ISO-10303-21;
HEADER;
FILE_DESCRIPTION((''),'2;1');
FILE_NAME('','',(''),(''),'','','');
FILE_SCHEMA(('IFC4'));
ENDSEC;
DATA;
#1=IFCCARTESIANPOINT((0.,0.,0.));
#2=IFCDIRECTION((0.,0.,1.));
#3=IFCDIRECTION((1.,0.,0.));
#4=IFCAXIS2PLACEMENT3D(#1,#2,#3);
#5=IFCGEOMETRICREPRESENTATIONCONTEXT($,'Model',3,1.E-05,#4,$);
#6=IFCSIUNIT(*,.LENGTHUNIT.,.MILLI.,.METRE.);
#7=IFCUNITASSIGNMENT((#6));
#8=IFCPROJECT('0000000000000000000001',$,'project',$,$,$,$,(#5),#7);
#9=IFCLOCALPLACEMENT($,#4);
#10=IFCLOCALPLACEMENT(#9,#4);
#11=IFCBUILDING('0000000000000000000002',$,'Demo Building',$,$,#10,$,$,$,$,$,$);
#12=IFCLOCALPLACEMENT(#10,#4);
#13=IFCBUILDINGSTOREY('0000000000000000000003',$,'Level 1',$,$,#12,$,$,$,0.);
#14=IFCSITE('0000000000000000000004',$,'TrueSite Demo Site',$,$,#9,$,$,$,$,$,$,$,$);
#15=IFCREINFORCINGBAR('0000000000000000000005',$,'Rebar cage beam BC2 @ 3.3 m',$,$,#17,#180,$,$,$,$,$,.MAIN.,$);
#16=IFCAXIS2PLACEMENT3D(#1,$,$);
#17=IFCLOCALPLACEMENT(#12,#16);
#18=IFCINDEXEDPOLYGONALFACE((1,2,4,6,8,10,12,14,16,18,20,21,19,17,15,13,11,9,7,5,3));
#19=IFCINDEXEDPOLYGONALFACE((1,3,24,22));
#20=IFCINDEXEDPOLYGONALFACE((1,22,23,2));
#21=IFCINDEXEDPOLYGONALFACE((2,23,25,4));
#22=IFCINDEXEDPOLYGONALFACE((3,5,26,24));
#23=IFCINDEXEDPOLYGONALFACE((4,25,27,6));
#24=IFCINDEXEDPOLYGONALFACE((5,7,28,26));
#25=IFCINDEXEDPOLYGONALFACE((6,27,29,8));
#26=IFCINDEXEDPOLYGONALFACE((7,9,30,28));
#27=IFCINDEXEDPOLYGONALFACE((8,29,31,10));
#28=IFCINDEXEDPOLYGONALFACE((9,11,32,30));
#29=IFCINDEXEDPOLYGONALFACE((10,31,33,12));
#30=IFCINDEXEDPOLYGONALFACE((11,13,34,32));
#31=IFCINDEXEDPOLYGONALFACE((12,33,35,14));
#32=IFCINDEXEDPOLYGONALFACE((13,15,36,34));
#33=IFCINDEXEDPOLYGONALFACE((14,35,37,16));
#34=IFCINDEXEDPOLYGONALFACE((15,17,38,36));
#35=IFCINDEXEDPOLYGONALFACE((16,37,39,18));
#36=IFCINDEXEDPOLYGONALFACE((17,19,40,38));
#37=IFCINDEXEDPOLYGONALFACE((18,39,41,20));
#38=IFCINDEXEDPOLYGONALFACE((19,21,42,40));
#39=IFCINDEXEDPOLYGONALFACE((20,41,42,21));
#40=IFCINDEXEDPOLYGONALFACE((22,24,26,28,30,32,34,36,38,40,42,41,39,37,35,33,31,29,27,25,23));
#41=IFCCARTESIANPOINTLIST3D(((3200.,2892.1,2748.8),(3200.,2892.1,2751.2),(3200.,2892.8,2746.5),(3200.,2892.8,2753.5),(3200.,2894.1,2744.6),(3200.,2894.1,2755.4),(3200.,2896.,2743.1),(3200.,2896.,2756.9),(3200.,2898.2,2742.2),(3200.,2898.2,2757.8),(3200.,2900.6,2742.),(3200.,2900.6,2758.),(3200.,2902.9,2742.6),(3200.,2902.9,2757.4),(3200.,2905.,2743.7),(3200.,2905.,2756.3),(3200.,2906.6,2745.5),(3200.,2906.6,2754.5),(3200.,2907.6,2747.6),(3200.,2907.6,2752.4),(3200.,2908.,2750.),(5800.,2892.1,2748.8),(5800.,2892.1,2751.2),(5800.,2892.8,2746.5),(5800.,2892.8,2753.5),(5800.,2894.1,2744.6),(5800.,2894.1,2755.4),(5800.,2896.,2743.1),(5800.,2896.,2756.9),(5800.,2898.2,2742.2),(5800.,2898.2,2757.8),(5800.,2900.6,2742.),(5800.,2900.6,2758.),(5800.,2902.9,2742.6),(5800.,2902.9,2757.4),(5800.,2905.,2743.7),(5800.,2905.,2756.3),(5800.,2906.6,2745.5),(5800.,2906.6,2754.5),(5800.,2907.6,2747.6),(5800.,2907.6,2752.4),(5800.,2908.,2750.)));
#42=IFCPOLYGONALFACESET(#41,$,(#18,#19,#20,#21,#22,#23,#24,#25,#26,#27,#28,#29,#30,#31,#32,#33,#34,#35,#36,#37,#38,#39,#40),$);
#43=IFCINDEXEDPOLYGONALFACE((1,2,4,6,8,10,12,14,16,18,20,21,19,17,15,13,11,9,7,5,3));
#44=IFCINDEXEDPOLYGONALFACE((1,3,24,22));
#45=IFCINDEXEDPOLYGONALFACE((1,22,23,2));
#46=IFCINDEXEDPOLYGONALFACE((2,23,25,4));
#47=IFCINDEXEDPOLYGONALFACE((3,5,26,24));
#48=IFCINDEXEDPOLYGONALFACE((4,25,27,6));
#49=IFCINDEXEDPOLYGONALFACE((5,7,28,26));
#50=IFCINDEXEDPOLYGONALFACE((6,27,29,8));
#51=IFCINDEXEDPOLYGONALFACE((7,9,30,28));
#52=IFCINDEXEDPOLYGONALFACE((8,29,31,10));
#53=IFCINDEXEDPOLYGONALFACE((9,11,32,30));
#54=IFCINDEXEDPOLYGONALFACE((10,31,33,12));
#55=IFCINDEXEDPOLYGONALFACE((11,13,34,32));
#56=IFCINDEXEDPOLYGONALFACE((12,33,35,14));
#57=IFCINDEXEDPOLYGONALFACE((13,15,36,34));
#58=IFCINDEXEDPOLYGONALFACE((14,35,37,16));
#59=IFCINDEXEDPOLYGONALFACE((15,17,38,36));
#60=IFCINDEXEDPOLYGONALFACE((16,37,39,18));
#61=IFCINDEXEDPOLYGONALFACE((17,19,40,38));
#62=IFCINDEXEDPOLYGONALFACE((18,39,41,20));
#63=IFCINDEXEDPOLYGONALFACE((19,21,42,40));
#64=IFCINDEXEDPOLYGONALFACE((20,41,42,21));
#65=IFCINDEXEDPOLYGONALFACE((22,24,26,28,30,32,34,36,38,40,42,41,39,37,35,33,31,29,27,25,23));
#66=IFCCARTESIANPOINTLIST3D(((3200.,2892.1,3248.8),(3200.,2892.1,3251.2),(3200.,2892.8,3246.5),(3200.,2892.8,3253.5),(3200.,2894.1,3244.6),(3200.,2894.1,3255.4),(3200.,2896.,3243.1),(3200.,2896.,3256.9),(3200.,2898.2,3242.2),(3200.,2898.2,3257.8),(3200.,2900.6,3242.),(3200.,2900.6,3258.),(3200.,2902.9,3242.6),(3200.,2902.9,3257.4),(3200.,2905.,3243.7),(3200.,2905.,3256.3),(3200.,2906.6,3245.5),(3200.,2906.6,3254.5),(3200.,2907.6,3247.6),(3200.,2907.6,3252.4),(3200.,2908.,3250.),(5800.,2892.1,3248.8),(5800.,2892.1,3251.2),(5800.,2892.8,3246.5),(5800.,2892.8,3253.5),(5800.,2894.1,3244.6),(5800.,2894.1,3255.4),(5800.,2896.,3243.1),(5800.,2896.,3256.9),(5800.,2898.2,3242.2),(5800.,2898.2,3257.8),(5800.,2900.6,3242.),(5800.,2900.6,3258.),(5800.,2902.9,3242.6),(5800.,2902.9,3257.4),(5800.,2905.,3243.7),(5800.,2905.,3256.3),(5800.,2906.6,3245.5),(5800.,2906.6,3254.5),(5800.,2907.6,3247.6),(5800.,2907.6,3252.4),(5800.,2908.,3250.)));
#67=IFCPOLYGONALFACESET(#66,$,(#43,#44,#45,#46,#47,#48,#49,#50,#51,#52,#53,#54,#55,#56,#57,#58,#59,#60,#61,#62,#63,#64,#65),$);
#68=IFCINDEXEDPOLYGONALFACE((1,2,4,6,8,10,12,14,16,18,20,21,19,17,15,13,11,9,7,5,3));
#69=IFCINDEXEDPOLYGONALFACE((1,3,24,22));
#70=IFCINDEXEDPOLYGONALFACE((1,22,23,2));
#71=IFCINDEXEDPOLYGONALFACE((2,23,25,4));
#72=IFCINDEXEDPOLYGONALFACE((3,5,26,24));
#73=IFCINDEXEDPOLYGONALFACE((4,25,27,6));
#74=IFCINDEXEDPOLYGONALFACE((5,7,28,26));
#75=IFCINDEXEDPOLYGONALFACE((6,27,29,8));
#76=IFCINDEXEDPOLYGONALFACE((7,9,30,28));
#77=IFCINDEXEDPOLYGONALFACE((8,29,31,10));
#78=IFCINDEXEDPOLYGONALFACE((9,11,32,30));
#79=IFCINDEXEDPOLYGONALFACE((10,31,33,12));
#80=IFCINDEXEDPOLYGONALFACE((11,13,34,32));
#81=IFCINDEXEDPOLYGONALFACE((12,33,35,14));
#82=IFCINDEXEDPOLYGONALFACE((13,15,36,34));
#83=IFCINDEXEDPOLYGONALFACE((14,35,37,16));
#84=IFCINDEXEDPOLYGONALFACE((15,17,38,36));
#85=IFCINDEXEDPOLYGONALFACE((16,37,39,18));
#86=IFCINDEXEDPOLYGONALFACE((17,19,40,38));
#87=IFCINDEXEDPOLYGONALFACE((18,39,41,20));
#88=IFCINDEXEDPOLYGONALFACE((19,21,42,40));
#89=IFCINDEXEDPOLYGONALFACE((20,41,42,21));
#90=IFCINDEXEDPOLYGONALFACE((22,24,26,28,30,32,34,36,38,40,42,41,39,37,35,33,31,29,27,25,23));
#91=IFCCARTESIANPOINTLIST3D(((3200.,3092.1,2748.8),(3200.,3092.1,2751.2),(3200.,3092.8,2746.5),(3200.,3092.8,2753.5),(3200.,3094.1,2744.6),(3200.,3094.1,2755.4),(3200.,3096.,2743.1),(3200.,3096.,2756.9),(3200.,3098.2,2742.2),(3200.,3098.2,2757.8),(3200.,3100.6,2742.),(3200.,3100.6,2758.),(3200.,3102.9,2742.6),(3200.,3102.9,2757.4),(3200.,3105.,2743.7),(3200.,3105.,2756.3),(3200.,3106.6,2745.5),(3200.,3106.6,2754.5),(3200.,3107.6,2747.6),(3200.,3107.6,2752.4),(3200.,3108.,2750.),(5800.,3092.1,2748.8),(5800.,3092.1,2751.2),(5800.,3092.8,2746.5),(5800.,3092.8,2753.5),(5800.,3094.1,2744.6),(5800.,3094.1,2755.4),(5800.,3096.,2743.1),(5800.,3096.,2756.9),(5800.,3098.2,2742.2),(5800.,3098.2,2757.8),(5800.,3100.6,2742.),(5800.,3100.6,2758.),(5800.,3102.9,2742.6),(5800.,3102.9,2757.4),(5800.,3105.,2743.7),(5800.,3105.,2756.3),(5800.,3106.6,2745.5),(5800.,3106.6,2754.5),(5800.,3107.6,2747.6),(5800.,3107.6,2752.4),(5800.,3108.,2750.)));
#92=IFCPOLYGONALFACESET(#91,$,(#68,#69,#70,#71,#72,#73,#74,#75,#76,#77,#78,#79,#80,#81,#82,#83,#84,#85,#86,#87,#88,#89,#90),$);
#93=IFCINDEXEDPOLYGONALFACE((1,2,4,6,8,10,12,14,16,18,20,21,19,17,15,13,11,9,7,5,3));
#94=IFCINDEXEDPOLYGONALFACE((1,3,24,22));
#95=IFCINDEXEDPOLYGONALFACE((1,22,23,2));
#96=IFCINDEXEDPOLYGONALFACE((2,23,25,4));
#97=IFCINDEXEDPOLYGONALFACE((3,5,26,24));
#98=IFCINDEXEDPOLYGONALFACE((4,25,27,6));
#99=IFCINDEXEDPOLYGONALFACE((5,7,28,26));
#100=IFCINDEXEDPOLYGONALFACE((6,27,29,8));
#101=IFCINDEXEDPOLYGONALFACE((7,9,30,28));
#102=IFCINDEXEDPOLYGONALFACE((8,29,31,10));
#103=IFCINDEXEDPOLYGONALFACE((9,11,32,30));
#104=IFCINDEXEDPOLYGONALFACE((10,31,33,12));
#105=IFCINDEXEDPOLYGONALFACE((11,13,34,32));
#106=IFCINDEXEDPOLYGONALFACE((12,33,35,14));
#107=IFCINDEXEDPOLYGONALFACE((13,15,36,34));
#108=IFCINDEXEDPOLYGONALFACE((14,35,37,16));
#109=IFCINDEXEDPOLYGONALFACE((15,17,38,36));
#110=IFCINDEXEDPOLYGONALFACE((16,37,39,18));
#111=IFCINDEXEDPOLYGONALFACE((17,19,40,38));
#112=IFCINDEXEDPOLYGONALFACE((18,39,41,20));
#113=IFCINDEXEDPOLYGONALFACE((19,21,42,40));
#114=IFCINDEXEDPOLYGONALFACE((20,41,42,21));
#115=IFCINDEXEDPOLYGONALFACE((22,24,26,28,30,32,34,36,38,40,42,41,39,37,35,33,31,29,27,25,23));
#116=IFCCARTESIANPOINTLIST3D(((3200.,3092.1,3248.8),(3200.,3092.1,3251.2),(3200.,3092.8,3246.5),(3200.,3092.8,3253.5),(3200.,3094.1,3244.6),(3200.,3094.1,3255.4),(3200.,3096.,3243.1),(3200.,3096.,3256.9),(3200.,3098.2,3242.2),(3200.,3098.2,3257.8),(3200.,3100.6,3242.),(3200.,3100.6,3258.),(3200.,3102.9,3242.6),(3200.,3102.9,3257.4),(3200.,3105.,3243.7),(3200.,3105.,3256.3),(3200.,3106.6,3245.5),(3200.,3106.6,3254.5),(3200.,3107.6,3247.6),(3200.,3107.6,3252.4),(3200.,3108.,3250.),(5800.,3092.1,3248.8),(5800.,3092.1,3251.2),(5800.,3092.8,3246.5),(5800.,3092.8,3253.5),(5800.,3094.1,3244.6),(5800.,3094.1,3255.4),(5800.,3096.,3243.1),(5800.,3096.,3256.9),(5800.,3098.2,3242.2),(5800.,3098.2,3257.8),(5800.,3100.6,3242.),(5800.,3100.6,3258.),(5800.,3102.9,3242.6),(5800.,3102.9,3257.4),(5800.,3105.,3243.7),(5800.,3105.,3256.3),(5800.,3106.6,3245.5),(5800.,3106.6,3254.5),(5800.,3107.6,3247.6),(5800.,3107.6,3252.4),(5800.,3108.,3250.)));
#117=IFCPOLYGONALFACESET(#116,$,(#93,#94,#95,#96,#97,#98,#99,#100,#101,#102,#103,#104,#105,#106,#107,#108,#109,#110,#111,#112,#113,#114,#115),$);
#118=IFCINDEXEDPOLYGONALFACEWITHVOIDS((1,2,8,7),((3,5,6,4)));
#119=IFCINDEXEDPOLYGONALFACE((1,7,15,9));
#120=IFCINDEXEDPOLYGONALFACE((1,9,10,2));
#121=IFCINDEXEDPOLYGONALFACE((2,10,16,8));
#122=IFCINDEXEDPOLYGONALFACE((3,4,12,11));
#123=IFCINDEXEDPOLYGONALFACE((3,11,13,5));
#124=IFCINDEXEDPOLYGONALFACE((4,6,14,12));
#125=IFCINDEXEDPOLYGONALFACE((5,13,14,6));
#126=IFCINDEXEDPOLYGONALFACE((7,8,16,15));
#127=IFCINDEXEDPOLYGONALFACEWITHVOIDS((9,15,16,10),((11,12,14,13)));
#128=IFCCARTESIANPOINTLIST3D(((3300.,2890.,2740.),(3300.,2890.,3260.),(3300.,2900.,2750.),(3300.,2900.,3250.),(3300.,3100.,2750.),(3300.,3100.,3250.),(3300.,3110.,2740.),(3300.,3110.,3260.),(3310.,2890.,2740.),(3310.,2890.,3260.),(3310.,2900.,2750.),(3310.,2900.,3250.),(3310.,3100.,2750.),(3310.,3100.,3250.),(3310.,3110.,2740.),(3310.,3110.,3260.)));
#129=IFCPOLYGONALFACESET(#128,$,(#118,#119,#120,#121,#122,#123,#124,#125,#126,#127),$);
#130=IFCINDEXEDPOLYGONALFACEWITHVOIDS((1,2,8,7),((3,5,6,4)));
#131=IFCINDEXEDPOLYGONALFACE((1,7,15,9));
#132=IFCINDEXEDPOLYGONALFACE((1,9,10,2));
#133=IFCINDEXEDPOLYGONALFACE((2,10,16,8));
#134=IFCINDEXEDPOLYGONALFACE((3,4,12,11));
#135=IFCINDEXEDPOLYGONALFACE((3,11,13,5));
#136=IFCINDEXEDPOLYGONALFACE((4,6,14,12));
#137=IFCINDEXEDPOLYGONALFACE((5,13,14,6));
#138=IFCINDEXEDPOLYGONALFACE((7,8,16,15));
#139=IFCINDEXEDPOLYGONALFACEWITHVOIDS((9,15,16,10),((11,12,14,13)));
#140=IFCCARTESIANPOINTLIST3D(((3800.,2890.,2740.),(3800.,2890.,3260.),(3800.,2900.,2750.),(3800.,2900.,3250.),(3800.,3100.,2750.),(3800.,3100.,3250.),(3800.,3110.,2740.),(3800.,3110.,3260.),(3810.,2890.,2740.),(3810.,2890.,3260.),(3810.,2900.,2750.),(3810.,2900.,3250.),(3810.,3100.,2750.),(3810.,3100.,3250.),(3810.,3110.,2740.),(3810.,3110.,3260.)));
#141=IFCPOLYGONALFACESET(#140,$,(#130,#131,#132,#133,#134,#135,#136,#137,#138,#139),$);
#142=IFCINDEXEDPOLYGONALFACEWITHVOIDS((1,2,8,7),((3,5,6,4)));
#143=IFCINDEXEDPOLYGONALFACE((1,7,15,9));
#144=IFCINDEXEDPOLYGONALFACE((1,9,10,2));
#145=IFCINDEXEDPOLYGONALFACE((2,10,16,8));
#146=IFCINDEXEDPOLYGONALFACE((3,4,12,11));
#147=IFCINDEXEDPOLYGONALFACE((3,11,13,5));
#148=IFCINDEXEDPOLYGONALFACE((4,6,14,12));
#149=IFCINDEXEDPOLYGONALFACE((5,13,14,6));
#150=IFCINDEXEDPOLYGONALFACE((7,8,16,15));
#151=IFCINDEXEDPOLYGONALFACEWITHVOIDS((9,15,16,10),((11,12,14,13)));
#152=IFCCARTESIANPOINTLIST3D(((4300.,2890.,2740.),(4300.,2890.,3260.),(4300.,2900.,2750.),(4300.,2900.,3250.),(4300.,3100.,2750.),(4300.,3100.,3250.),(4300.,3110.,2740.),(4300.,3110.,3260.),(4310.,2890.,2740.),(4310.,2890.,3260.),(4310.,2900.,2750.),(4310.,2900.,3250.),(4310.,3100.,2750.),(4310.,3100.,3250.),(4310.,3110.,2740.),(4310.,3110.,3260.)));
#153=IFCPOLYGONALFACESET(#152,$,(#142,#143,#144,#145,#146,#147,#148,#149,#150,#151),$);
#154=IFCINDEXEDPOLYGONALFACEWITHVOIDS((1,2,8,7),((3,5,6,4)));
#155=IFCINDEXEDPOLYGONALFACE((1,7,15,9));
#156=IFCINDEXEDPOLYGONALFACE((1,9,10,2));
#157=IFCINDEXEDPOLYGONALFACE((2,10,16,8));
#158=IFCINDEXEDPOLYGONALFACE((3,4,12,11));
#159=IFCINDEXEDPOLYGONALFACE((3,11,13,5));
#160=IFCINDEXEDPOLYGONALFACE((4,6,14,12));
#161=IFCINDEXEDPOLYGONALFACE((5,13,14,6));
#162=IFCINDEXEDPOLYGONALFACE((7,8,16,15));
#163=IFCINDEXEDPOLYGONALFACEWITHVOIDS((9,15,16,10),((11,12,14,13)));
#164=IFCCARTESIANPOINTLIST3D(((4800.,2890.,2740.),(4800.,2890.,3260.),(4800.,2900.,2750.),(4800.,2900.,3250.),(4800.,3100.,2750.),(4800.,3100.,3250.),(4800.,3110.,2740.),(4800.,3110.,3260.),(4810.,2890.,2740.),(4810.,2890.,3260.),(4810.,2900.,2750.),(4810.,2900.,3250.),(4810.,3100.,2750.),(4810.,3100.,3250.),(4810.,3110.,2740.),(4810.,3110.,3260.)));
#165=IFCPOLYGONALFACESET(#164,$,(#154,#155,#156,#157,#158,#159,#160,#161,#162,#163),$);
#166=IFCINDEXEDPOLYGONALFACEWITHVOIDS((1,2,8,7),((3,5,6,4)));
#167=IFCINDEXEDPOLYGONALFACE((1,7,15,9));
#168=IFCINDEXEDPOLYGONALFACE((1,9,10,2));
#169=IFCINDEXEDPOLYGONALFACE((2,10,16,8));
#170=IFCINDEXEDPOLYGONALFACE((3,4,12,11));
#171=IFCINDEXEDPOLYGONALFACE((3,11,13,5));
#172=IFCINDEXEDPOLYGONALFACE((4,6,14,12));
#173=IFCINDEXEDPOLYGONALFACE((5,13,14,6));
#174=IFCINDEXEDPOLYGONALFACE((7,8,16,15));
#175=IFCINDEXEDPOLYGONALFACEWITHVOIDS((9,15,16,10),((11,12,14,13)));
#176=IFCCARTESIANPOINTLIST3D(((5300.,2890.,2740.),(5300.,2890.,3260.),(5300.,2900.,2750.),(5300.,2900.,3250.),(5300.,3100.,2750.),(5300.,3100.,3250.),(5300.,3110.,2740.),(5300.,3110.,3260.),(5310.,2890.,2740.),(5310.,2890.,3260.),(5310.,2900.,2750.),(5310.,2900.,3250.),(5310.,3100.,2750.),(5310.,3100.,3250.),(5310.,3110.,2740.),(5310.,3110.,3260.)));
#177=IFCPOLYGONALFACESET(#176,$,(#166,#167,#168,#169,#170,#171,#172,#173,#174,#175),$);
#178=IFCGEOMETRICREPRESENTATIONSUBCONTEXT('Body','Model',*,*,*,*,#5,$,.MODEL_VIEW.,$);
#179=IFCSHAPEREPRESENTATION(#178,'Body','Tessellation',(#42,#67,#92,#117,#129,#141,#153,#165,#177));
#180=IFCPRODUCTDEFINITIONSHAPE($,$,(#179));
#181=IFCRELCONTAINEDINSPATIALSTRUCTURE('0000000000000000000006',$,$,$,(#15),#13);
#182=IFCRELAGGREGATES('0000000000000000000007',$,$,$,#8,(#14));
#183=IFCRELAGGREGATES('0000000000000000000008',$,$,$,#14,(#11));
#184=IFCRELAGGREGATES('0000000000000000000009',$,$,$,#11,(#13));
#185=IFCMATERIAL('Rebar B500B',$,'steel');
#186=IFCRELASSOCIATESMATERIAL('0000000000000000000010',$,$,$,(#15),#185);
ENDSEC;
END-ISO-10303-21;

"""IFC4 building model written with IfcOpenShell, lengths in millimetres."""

from ifc_helpers import new_model, si_unit, frame, origin_with_axes, place, context, subcontext, project, spatial, hollow_rectangle, circle, extrude, material, element, save


model = new_model("IFC4")

# Units and contexts
model_context = context("Model", 3, precision=1e-05, world=origin_with_axes())
body_context = subcontext(model_context, "Body", "Model", "MODEL_VIEW")
ifc_project = project(units=[si_unit("LENGTHUNIT", "METRE", prefix="MILLI")], contexts=[model_context])

# Site, building, storey
site_placement = place(None, origin_with_axes())
site = spatial("IfcSite", under=ifc_project, at=site_placement, Name="TrueSite Demo Site")
building_placement = place(site_placement, origin_with_axes())
building = spatial("IfcBuilding", under=site, at=building_placement, Name="Demo Building")
storey_placement = place(building_placement, origin_with_axes())
storey = spatial("IfcBuildingStorey", under=building, at=storey_placement, Name="Level 1", Elevation=0.0)

# Reinforcing bar
ifc_material_1 = material(Name="Rebar B500B", Category="steel")
for number, where, z_axis, x_axis, name in (
    (1, (3200.0, 3000.0, 3000.0), (1.0, 0.0, 0.0), (0.0, 1.0, 0.0), "Rebar cage beam BC2 @ 3.3 m"),
):
    element("IfcReinforcingBar", number, at=place(storey_placement, frame(where, z_axis=z_axis, x_axis=x_axis)), inside=storey, material=ifc_material_1, Name=name, PredefinedType="MAIN", context=body_context, shape_type="SweptSolid", body=[
        extrude(circle(Radius=8.0), frame((-100.0, -250.0, 0.0)), (0.0, 0.0, 1.0), 2600.0),
        extrude(circle(Radius=8.0), frame((-100.0, 250.0, 0.0)), (0.0, 0.0, 1.0), 2600.0),
        extrude(circle(Radius=8.0), frame((100.0, -250.0, 0.0)), (0.0, 0.0, 1.0), 2600.0),
        extrude(circle(Radius=8.0), frame((100.0, 250.0, 0.0)), (0.0, 0.0, 1.0), 2600.0),
        extrude(hollow_rectangle(XDim=220.0, YDim=520.0, WallThickness=10.0), frame((0.0, 0.0, 100.0)), (0.0, 0.0, 1.0), 10.0),
        extrude(hollow_rectangle(XDim=220.0, YDim=520.0, WallThickness=10.0), frame((0.0, 0.0, 600.0)), (0.0, 0.0, 1.0), 10.0),
        extrude(hollow_rectangle(XDim=220.0, YDim=520.0, WallThickness=10.0), frame((0.0, 0.0, 1100.0)), (0.0, 0.0, 1.0), 10.0),
        extrude(hollow_rectangle(XDim=220.0, YDim=520.0, WallThickness=10.0), frame((0.0, 0.0, 1600.0)), (0.0, 0.0, 1.0), 10.0),
        extrude(hollow_rectangle(XDim=220.0, YDim=520.0, WallThickness=10.0), frame((0.0, 0.0, 2100.0)), (0.0, 0.0, 1.0), 10.0),
    ])

save(model, "model.ifc")
